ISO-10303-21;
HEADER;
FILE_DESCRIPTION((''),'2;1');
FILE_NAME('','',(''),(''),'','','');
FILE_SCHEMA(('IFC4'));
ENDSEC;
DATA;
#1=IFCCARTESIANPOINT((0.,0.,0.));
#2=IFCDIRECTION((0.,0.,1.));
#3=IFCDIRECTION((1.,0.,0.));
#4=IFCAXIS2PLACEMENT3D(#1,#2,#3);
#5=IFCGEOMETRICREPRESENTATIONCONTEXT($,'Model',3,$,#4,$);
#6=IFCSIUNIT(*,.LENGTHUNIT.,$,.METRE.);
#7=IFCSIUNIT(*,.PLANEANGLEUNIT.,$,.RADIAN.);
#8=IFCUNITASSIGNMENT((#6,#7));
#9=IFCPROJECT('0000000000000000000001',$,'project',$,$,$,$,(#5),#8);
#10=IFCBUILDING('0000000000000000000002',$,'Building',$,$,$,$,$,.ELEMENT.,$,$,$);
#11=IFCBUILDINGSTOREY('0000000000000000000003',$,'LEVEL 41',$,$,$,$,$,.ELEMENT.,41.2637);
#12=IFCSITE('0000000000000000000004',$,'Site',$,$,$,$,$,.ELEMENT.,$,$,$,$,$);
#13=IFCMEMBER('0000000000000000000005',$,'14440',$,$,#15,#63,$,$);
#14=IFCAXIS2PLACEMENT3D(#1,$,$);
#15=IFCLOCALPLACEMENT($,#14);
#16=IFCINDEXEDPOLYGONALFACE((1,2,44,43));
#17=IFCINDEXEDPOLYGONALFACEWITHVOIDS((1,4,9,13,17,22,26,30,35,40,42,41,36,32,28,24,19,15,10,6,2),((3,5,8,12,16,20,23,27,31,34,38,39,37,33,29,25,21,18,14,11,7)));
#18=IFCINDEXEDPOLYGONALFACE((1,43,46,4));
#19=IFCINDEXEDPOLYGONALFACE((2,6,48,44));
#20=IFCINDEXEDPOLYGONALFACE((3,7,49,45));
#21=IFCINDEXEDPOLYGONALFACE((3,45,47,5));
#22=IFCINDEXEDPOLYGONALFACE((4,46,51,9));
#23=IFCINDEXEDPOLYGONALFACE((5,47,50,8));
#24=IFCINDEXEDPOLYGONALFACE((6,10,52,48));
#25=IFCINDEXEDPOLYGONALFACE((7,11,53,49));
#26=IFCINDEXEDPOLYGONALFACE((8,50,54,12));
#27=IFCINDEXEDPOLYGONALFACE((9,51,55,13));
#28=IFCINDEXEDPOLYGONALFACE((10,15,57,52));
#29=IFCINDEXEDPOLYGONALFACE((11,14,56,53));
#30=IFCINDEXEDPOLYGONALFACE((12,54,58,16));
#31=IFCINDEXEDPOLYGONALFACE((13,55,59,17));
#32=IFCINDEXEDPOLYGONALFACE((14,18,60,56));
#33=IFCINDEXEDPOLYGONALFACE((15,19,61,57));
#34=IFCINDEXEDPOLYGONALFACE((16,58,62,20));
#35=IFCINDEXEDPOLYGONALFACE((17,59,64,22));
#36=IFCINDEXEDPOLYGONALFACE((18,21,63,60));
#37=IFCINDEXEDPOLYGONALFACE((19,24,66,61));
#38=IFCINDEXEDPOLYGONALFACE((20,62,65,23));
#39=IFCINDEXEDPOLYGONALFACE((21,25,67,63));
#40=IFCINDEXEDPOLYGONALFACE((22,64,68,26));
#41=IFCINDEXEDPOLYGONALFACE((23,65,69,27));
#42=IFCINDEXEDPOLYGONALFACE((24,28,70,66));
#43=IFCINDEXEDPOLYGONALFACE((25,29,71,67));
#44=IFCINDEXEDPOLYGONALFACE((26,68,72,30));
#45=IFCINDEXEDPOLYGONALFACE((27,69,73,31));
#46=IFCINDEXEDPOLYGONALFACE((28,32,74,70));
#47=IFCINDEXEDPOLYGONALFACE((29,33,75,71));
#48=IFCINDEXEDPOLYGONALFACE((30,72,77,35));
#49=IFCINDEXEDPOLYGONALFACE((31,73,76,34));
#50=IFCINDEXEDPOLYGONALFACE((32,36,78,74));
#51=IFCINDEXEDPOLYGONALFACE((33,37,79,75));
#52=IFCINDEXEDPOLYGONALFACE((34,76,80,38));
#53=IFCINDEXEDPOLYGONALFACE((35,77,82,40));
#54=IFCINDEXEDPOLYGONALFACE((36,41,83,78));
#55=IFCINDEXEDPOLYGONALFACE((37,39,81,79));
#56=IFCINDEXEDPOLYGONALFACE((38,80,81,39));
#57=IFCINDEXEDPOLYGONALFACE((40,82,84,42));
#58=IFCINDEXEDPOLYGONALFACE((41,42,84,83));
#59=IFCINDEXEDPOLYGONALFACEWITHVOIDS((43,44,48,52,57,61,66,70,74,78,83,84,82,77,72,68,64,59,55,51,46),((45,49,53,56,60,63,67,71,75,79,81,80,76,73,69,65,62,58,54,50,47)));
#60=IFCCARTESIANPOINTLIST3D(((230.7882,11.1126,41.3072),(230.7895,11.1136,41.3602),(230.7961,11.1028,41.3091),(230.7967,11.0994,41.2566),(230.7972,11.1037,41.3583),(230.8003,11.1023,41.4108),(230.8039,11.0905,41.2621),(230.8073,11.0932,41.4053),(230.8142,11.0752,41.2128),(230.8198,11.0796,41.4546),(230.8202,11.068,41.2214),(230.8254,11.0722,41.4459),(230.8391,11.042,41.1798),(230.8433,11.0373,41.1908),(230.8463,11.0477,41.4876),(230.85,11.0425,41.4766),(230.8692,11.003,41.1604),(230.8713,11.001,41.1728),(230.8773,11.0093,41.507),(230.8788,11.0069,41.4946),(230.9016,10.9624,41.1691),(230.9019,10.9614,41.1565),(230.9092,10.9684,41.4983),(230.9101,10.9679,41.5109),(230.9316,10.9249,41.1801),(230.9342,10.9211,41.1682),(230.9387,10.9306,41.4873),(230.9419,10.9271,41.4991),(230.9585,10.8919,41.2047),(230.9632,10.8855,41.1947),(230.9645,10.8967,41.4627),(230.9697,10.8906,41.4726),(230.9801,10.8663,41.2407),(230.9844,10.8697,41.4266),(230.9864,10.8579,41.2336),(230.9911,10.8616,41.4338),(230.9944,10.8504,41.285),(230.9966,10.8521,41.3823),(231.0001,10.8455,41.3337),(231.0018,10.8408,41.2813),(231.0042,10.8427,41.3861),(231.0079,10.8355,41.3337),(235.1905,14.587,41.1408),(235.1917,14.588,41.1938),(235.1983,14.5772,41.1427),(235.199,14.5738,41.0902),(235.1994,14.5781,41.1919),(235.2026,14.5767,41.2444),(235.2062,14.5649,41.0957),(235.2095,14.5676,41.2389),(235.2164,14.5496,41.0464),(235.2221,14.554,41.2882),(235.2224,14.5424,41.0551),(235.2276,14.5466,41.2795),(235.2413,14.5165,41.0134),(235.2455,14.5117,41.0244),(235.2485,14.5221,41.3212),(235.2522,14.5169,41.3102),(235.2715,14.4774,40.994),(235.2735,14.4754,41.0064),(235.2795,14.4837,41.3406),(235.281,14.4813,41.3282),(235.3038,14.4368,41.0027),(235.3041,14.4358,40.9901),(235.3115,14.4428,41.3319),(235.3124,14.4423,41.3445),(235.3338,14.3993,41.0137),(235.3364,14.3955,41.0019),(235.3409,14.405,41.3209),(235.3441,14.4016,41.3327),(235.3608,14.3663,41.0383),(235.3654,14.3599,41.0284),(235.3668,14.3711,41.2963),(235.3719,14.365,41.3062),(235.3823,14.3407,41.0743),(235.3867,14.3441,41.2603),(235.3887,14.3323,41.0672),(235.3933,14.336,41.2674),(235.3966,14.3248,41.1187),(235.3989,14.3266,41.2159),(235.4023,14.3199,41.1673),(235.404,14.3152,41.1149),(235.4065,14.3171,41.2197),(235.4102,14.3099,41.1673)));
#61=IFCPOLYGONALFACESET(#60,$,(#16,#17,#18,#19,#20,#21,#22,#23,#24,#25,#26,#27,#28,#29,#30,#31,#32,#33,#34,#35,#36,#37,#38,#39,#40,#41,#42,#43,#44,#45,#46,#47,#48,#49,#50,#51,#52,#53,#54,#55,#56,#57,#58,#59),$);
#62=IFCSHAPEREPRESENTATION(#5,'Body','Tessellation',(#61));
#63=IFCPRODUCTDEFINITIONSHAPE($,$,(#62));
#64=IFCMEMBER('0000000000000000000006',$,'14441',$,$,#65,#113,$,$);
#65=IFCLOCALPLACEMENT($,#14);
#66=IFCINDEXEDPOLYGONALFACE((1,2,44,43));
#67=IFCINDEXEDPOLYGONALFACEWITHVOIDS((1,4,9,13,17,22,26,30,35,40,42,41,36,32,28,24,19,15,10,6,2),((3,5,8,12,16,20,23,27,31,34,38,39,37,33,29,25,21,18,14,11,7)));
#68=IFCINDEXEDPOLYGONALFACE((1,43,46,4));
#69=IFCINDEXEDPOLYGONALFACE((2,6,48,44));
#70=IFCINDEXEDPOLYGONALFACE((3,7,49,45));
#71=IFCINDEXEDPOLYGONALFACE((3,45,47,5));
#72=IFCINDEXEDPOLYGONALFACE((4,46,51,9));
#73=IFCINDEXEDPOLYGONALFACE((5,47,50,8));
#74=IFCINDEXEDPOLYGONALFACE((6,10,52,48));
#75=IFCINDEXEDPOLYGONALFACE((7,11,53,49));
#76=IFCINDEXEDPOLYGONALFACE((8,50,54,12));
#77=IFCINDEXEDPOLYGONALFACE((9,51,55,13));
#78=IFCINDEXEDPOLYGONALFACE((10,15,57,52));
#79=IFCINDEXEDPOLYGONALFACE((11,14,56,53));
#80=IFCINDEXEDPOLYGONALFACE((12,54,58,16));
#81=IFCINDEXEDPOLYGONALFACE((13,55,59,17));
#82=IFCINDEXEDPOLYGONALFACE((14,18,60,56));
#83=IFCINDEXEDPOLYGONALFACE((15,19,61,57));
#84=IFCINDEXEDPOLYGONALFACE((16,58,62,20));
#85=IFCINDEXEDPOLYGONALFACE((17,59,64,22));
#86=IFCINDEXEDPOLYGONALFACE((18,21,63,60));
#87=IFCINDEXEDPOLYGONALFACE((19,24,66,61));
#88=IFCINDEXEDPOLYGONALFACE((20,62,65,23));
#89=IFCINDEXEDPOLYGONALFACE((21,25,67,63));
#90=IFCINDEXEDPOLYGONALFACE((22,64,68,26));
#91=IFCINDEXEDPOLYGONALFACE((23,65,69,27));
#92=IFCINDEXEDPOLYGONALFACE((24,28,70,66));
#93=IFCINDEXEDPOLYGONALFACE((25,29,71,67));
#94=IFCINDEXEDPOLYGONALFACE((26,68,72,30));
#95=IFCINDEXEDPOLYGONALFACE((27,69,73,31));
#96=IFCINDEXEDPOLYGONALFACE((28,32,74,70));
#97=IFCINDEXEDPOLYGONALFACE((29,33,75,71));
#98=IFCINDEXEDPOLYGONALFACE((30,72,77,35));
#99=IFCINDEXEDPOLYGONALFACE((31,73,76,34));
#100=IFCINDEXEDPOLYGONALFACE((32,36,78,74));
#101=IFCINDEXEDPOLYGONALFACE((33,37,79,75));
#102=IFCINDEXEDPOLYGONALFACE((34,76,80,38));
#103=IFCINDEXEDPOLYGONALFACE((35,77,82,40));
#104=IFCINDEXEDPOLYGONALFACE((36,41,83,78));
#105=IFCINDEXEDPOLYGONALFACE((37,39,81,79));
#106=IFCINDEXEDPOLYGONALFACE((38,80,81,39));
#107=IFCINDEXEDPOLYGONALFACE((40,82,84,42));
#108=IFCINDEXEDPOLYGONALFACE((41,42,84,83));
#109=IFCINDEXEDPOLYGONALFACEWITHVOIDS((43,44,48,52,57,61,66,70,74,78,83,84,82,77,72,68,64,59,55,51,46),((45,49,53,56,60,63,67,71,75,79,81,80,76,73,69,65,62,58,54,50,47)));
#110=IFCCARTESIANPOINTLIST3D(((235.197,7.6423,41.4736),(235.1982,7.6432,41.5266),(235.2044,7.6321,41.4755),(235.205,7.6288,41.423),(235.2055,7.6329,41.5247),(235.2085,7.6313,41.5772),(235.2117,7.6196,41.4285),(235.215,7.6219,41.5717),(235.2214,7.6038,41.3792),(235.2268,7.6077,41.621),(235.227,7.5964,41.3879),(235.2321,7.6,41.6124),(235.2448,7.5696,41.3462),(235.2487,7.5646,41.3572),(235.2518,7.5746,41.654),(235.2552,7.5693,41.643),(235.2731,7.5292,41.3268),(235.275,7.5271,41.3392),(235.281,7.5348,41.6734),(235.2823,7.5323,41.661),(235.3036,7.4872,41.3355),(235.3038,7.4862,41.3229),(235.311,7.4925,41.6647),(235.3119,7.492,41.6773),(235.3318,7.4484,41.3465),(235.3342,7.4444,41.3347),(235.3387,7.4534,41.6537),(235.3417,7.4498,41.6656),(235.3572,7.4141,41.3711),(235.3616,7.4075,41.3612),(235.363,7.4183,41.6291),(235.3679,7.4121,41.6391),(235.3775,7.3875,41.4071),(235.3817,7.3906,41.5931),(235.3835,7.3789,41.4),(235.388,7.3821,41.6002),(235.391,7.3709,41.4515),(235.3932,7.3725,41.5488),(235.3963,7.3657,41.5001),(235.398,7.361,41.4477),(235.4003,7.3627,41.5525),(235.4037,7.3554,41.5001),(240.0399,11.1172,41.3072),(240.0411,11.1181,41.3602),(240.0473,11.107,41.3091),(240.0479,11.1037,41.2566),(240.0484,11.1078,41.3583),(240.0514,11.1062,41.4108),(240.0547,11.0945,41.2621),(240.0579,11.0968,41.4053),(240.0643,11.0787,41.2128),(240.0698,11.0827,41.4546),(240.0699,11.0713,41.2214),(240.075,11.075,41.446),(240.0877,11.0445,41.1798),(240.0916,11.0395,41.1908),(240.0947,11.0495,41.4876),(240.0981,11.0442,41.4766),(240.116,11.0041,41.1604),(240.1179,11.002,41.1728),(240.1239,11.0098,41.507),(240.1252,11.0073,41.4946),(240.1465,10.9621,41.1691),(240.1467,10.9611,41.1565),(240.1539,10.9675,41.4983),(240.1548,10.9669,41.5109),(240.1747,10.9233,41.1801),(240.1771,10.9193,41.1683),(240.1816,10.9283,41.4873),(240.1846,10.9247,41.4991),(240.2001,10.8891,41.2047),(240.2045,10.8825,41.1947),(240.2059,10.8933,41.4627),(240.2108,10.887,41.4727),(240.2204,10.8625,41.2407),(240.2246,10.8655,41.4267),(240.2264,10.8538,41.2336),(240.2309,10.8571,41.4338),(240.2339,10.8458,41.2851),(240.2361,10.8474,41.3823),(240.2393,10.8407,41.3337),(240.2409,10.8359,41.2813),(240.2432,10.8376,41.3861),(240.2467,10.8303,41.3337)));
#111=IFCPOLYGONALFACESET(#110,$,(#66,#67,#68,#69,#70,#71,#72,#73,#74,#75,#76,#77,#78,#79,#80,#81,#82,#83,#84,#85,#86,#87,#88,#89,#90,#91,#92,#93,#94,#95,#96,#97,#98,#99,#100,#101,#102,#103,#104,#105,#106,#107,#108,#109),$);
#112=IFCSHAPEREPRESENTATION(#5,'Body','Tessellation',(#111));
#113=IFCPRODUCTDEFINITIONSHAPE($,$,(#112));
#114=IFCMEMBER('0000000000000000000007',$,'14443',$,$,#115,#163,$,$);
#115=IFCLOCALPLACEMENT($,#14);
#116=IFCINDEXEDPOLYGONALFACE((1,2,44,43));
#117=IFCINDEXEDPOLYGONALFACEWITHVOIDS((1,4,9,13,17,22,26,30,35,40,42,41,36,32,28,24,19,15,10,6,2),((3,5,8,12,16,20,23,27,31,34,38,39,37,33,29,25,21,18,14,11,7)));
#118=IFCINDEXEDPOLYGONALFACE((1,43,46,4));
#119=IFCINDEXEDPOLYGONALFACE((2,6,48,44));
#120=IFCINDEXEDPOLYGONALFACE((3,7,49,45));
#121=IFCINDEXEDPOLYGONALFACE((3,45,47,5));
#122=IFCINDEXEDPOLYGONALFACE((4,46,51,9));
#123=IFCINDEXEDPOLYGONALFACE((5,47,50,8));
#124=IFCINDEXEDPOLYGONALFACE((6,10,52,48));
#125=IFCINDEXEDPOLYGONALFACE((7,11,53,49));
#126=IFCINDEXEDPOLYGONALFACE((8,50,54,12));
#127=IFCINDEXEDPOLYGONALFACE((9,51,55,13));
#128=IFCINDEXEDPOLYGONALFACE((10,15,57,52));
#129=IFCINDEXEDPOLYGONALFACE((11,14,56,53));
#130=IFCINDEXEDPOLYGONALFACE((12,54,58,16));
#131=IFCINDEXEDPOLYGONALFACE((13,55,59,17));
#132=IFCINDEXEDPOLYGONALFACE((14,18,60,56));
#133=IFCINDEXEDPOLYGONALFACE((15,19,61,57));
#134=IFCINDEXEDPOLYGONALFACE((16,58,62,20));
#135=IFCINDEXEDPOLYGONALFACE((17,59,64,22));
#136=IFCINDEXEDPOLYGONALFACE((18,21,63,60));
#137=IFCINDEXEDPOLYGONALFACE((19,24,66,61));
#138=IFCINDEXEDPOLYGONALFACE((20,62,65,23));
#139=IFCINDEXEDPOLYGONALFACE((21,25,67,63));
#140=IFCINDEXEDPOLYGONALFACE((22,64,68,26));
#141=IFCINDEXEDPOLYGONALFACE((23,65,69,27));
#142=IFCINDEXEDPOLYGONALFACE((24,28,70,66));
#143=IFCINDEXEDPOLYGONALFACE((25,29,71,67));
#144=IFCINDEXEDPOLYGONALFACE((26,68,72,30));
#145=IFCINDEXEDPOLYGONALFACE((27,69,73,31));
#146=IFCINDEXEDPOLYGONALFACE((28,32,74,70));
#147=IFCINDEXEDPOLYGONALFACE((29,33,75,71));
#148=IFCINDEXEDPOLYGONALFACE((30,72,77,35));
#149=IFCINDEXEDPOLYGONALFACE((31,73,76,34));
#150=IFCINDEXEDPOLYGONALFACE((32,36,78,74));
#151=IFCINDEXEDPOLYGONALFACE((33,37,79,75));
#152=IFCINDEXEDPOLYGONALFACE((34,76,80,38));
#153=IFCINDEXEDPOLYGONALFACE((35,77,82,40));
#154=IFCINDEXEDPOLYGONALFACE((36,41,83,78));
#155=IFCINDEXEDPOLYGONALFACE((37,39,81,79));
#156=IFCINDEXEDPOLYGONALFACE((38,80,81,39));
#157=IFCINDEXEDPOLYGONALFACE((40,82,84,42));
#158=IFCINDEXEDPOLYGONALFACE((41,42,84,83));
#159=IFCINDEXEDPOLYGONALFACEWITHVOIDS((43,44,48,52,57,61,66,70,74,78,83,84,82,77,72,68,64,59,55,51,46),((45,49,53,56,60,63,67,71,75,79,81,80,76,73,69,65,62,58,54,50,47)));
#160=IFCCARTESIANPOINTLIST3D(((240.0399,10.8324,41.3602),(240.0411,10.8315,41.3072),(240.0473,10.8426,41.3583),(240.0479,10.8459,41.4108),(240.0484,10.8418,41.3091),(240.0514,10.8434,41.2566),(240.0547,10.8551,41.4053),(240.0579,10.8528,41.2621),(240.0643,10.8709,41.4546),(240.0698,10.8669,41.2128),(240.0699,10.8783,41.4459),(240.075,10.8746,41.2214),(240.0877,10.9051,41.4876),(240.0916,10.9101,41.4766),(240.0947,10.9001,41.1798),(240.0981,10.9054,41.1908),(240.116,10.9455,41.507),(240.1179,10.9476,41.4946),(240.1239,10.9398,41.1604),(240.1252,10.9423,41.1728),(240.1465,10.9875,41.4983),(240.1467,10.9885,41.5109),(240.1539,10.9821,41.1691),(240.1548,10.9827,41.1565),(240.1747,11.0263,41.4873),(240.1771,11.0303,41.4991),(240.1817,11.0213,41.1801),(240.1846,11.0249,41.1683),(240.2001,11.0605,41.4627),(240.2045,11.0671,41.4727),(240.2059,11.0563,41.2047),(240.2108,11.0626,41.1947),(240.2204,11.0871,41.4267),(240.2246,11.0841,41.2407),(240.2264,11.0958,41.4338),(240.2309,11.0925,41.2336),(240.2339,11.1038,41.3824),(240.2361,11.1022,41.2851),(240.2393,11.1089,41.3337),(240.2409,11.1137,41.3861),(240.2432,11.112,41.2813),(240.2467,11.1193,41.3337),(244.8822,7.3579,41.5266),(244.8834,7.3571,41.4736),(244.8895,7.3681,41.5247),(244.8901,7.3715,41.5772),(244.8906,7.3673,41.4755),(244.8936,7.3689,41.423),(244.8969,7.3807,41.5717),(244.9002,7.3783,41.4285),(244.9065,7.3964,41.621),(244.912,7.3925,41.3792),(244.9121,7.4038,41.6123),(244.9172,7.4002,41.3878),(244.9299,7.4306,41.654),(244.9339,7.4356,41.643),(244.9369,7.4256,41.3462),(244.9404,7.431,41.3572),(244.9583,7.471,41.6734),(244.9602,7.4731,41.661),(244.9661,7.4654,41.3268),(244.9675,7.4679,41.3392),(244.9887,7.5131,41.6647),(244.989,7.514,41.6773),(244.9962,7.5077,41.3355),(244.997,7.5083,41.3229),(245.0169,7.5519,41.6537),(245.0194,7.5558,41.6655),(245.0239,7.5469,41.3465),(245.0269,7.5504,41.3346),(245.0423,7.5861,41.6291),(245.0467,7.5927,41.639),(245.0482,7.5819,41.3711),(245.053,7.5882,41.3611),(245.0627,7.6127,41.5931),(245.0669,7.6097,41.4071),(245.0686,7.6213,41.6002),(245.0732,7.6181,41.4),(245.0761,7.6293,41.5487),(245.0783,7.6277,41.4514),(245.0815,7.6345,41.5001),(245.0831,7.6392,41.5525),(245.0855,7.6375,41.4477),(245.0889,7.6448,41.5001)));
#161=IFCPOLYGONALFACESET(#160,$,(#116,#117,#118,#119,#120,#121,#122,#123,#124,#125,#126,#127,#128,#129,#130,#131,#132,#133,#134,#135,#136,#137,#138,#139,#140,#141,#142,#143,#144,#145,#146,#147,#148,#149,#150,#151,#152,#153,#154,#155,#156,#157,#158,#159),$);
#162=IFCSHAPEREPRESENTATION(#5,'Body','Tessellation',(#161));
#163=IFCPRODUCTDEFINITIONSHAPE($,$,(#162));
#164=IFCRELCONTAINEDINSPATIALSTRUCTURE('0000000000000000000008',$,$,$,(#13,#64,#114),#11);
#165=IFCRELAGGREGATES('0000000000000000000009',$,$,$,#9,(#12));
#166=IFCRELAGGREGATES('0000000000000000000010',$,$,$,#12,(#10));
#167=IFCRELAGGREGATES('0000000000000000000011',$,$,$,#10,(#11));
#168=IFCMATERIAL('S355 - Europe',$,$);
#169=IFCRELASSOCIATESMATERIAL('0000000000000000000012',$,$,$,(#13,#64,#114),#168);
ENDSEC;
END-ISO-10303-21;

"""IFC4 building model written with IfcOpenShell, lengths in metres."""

from ifc_helpers import new_model, si_unit, frame, origin_with_axes, origin_2d_with_axis, place, context, project, spatial, hollow_circle, extrude, material, material_profile, profile_set, profile_usage, element, save


model = new_model("IFC4")

# Units and contexts
model_context = context("Model", 3, world=origin_with_axes())
ifc_project = project(units=[si_unit("LENGTHUNIT", "METRE"), si_unit("PLANEANGLEUNIT", "RADIAN")], contexts=[model_context])

# Site, building, storey
site = spatial("IfcSite", under=ifc_project, Name="Site", CompositionType="ELEMENT")
building = spatial("IfcBuilding", under=site, Name="Building", CompositionType="ELEMENT")
storey = spatial("IfcBuildingStorey", under=building, Name="LEVEL 41", CompositionType="ELEMENT", Elevation=41.2637)

# Shared definitions
ifc_material = material(Name="S355 - Europe")

# Members
ifc_material_profile_1 = material_profile(ifc_material, hollow_circle(Radius=0.1778, WallThickness=0.0127, at=origin_2d_with_axis()))
ifc_profile_set_1 = profile_set([ifc_material_profile_1])
ifc_profile_usage_1 = profile_usage(ifc_profile_set_1, cardinal=10)
member_1_placement = place(None, frame((235.3, 14.4495, 41.1673), z_axis=(-0.784627, -0.619258, 0.029656), x_axis=(0.619389, -0.785084, 0.0)))
element("IfcMember", 1, at=member_1_placement, inside=storey, material=ifc_profile_usage_1, Name="14440", context=model_context, shape_type="SweptSolid", body=[
    extrude(hollow_circle(Radius=0.1778, WallThickness=0.0127, at=origin_2d_with_axis()), origin_with_axes(), (0.0, 0.0, 1.0), 5.6106),
])
ifc_material_profile_2 = material_profile(ifc_material, hollow_circle(Radius=0.1778, WallThickness=0.0127, at=origin_2d_with_axis()))
ifc_profile_set_2 = profile_set([ifc_material_profile_2])
ifc_profile_usage_2 = profile_usage(ifc_profile_set_2, cardinal=10)
member_2_placement = place(None, frame((240.143, 10.9748, 41.3337), z_axis=(-0.812169, -0.582754, 0.027908), x_axis=(0.582981, -0.812486, 0.0)))
element("IfcMember", 2, at=member_2_placement, inside=storey, material=ifc_profile_usage_2, Name="14441", context=model_context, shape_type="SweptSolid", body=[
    extrude(hollow_circle(Radius=0.1778, WallThickness=0.0127, at=origin_2d_with_axis()), origin_with_axes(), (0.0, 0.0, 1.0), 5.9629),
])
ifc_material_profile_3 = material_profile(ifc_material, hollow_circle(Radius=0.1778, WallThickness=0.0127, at=origin_2d_with_axis()))
ifc_profile_set_3 = profile_set([ifc_material_profile_3])
ifc_profile_usage_3 = profile_usage(ifc_profile_set_3, cardinal=10)
member_3_placement = place(None, frame((240.143, 10.9748, 41.3337), z_axis=(0.812169, -0.582754, 0.027908), x_axis=(0.582077, 0.813134, 0.0)))
element("IfcMember", 3, at=member_3_placement, inside=storey, material=ifc_profile_usage_3, Name="14443", context=model_context, shape_type="SweptSolid", body=[
    extrude(hollow_circle(Radius=0.1778, WallThickness=0.0127, at=origin_2d_with_axis()), origin_with_axes(), (0.0, 0.0, 1.0), 5.9621),
])

save(model, "model.ifc")
